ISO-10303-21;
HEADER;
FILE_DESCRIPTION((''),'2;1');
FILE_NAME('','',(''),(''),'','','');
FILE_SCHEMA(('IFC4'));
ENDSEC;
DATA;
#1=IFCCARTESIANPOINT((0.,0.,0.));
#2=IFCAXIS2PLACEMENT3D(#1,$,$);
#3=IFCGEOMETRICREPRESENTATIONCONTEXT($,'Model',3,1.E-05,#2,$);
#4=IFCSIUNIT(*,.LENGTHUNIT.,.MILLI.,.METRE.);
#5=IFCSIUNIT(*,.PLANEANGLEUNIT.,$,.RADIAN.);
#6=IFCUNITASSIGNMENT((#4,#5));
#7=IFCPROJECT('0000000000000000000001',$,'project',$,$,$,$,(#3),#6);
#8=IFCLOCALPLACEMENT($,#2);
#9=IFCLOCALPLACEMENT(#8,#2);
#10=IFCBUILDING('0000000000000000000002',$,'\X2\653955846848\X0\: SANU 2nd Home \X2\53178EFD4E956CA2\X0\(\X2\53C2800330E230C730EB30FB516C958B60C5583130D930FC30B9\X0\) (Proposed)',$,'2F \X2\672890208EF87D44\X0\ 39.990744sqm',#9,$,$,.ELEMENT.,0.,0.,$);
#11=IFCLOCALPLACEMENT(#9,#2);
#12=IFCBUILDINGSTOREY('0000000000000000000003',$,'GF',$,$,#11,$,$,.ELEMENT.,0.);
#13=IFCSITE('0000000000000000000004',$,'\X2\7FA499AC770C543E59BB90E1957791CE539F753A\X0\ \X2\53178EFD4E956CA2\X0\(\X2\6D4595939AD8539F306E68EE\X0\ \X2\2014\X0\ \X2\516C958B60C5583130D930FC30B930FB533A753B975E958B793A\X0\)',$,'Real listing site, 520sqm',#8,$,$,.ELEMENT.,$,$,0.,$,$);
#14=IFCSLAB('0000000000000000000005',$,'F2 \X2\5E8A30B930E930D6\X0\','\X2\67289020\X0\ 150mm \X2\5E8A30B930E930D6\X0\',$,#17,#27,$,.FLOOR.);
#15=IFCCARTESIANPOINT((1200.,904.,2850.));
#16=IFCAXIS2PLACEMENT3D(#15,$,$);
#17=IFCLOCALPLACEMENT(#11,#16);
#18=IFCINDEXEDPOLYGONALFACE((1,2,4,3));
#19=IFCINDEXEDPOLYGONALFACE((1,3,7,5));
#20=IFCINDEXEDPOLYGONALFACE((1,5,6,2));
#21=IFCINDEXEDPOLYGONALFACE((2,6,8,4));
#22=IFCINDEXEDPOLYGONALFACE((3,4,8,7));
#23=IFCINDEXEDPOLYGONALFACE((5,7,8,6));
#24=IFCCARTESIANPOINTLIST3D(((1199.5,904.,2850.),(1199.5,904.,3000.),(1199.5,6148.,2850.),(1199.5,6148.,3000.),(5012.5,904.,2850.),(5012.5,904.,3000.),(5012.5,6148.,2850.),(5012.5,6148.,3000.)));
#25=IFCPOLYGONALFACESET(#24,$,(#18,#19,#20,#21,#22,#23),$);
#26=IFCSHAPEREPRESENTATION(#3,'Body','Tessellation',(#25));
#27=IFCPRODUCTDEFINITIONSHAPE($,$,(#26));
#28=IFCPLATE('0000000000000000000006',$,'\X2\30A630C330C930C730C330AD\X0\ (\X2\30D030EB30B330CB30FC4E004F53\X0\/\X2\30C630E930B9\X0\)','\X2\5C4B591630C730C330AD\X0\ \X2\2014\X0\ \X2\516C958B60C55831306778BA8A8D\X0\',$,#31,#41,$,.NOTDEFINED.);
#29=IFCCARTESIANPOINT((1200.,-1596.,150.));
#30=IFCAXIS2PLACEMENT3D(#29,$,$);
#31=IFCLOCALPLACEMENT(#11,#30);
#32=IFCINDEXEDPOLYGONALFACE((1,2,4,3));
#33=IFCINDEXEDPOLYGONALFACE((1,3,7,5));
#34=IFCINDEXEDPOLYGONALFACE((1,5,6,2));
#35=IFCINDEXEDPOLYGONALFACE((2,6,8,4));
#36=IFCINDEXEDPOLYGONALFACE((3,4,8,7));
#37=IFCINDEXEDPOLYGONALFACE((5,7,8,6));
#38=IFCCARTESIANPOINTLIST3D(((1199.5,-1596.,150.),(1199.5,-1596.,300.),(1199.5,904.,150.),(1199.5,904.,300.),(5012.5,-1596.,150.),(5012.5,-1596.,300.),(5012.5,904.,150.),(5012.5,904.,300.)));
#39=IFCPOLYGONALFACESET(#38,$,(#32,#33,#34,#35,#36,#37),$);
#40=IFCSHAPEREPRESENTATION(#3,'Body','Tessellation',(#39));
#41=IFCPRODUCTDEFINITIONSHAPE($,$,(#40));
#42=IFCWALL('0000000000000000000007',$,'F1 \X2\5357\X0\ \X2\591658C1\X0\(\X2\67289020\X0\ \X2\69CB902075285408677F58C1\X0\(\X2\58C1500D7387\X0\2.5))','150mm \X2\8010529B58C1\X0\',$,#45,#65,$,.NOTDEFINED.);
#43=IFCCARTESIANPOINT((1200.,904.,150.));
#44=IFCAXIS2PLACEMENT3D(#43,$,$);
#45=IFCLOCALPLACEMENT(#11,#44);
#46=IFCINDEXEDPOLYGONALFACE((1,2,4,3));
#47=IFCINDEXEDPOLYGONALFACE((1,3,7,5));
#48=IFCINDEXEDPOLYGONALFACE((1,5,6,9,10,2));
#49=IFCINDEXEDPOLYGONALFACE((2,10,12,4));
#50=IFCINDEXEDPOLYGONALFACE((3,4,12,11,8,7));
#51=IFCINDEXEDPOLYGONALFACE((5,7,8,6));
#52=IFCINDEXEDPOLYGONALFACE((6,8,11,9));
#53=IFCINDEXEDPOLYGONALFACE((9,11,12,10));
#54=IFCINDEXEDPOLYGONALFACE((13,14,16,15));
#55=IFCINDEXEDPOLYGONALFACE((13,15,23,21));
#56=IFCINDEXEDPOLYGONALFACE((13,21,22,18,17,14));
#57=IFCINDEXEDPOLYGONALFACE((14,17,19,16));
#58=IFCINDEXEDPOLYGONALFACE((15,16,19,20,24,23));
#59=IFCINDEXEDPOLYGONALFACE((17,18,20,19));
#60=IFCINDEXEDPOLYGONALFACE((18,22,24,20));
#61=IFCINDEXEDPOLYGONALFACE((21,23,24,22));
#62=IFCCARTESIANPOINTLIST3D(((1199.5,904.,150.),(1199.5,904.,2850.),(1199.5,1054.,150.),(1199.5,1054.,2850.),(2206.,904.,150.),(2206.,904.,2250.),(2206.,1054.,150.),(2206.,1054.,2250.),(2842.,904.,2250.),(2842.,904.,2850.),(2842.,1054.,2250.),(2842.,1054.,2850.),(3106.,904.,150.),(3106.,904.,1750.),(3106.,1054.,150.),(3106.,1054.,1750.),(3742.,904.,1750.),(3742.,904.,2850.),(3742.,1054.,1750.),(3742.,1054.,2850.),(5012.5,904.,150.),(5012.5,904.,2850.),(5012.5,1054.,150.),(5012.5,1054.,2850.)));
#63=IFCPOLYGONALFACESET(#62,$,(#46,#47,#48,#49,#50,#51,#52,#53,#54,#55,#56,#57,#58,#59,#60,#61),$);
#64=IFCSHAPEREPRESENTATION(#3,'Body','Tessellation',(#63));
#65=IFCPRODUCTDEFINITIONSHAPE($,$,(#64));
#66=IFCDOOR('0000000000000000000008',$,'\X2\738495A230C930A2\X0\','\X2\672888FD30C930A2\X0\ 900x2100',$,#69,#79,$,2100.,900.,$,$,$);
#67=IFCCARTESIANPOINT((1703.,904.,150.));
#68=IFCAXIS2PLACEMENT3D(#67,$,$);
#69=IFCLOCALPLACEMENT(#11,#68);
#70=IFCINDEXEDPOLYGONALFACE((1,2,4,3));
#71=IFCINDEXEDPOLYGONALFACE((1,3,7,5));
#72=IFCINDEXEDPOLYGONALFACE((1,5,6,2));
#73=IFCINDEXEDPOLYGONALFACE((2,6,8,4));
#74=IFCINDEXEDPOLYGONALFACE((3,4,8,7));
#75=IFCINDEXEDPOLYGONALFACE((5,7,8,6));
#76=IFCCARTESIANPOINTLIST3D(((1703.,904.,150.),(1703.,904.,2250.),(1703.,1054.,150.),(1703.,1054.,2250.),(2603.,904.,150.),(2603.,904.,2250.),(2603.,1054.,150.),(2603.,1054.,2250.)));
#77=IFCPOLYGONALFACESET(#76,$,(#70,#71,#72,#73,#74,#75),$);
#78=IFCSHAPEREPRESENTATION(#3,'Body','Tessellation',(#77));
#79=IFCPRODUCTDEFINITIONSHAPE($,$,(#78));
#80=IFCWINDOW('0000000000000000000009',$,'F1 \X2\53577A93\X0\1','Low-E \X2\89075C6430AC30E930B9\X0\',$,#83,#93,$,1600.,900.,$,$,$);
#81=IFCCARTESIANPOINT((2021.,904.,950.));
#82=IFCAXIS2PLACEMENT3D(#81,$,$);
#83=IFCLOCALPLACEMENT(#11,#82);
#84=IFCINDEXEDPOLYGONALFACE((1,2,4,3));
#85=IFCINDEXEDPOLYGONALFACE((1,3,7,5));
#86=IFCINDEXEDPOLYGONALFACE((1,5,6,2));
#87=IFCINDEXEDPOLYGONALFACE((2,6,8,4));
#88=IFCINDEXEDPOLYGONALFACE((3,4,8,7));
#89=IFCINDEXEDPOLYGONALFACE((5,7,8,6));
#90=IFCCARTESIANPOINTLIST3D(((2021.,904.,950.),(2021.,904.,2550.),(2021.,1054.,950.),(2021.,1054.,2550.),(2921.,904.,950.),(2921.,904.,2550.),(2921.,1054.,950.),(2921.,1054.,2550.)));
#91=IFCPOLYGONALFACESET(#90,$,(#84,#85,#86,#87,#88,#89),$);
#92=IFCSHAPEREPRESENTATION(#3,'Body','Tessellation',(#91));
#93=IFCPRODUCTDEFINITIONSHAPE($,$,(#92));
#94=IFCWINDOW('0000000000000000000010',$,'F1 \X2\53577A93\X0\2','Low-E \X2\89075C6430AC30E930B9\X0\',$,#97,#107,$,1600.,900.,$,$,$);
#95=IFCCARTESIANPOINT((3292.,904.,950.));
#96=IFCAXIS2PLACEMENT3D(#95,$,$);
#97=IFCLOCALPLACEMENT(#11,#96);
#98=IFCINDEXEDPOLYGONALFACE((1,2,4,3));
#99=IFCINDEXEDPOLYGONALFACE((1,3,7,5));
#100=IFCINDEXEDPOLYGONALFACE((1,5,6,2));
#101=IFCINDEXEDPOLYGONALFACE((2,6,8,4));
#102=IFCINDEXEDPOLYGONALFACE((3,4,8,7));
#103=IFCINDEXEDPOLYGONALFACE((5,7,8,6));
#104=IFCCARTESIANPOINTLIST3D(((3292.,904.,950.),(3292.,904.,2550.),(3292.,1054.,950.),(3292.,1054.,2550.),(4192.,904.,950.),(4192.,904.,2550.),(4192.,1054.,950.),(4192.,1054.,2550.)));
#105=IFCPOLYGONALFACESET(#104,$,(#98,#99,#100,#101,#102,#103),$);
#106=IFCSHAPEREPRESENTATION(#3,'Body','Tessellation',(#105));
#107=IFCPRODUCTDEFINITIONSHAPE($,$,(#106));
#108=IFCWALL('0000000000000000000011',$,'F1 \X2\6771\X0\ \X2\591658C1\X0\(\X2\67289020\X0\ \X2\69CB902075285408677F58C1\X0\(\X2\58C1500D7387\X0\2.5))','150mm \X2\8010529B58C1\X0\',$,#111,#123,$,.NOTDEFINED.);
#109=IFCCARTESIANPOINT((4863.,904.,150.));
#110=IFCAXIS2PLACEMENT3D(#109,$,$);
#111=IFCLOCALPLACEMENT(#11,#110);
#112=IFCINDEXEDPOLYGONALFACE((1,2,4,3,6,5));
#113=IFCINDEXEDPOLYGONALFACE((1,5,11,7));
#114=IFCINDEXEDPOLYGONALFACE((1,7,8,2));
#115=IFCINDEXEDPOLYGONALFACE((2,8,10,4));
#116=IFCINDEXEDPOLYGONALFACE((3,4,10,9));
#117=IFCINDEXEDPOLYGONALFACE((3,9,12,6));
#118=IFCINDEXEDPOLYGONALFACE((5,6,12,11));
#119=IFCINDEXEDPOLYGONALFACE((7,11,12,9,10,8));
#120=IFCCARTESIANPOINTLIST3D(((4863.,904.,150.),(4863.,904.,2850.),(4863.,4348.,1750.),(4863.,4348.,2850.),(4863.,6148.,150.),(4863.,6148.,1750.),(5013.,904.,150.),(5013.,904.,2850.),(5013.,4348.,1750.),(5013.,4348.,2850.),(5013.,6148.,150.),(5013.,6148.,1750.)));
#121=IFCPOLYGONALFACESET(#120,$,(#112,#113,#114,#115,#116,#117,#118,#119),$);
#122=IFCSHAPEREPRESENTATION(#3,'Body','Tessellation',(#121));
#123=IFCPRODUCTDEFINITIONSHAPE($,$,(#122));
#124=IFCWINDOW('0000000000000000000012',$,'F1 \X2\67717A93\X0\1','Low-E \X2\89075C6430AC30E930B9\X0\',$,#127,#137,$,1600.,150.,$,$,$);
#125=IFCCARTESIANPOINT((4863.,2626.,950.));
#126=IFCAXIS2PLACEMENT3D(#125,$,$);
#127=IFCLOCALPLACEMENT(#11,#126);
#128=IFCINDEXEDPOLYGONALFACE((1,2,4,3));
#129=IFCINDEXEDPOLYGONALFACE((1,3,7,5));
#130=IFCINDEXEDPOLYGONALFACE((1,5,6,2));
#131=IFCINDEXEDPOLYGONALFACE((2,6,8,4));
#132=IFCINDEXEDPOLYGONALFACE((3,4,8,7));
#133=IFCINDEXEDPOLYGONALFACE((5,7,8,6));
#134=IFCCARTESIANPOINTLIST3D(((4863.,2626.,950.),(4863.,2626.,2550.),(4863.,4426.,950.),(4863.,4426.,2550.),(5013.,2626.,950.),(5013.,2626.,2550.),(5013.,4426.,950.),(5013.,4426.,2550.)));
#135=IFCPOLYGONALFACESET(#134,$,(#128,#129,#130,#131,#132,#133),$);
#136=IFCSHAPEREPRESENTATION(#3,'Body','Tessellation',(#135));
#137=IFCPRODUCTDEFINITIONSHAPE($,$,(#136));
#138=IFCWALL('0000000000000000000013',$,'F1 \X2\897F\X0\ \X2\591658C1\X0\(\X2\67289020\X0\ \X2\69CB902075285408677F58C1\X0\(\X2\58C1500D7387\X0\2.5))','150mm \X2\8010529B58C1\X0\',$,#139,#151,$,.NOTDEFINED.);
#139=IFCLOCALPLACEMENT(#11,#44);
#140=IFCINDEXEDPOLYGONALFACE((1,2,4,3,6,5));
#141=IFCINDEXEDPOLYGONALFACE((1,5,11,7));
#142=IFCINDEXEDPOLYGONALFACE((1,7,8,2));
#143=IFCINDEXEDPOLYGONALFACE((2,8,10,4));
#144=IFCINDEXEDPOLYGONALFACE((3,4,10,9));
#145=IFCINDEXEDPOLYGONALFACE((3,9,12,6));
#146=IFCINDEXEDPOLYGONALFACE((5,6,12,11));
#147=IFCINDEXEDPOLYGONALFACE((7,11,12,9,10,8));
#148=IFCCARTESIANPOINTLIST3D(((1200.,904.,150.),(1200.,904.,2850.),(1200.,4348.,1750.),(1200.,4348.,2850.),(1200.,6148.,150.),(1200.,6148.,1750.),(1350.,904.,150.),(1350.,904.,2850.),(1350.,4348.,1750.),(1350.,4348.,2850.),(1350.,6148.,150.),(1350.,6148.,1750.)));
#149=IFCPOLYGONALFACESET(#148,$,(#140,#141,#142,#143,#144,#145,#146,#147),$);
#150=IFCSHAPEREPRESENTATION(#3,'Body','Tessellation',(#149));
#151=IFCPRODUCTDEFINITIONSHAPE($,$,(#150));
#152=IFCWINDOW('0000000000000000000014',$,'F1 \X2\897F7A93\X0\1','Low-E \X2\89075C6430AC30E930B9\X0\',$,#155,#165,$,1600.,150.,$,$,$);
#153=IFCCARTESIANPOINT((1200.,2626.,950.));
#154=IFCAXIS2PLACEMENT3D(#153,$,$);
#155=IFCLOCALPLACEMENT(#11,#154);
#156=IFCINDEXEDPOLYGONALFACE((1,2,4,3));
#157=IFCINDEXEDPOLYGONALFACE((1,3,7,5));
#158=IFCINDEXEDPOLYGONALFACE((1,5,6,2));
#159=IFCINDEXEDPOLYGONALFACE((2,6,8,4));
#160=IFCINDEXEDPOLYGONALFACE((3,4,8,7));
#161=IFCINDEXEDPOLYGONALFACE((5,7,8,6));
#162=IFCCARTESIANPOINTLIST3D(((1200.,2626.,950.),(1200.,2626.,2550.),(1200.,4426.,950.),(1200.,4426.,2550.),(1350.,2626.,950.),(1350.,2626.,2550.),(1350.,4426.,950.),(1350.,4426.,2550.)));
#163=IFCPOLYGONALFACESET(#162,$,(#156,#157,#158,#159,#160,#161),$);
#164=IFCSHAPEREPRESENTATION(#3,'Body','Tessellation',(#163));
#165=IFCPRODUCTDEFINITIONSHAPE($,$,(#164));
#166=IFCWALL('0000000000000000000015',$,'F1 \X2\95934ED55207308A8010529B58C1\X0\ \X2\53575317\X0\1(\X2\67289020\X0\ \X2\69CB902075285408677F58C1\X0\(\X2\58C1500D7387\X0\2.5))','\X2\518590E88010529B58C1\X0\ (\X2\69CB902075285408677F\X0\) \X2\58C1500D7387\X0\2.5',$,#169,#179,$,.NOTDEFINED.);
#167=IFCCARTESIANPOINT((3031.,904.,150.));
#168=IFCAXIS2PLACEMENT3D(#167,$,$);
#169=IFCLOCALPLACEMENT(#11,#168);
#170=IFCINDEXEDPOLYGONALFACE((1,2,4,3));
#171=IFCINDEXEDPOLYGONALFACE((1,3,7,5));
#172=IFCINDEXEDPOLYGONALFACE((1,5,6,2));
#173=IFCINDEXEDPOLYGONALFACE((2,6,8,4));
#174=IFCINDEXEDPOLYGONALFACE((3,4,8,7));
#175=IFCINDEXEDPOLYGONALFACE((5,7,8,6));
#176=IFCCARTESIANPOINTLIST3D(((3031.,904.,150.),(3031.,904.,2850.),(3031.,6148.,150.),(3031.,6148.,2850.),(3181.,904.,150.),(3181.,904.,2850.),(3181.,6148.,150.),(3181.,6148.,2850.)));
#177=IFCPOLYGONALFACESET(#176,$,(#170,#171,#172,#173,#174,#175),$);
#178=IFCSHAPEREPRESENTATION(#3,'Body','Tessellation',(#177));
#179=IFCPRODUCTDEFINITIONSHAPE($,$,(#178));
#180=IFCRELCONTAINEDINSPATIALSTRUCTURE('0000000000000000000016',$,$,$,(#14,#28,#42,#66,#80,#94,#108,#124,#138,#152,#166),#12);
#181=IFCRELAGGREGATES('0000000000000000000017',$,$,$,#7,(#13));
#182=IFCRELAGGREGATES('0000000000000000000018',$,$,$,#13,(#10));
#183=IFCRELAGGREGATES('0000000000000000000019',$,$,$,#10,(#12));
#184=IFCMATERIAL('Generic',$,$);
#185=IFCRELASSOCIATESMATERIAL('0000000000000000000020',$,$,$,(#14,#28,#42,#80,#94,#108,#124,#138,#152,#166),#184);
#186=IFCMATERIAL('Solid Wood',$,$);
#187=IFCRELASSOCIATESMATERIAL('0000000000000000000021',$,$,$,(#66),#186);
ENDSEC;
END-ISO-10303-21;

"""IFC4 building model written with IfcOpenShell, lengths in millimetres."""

from ifc_helpers import new_model, si_unit, frame, frame_2d, origin, place, context, project, spatial, rectangle, extrude, material, element, fill, save


model = new_model("IFC4")

# Units and contexts
model_context = context("Model", 3, precision=1e-05, world=origin())
ifc_project = project(units=[si_unit("LENGTHUNIT", "METRE", prefix="MILLI"), si_unit("PLANEANGLEUNIT", "RADIAN")], contexts=[model_context])

# Site, building, storey
site_placement = place(None, origin())
site = spatial("IfcSite", under=ifc_project, at=site_placement, Name="群馬県吾妻郡長野原町 北軽井沢(浅間高原の森 — 公開情報ベース・区画非開示)", ObjectType="Real listing site, 520sqm", CompositionType="ELEMENT", RefElevation=0.0)
building_placement = place(site_placement, origin())
building = spatial("IfcBuilding", under=site, at=building_placement, Name="改善案: SANU 2nd Home 北軽井沢(参考モデル・公開情報ベース) (Proposed)", ObjectType="2F 木造軸組 39.990744sqm", CompositionType="ELEMENT", ElevationOfRefHeight=0.0, ElevationOfTerrain=0.0)
storey_placement = place(building_placement, origin())
storey = spatial("IfcBuildingStorey", under=building, at=storey_placement, Name="GF", CompositionType="ELEMENT", Elevation=0.0)

# Slab
ifc_material_1 = material(Name="Generic")
slab_1_placement = place(storey_placement, frame((1200.0, 904.0, 2850.0)))
element("IfcSlab", 1, at=slab_1_placement, inside=storey, material=ifc_material_1, Name="F2 床スラブ", Description="木造 150mm 床スラブ", PredefinedType="FLOOR", context=model_context, shape_type="SweptSolid", body=[
    extrude(rectangle(XDim=3813.0, YDim=5244.0, at=frame_2d((1906.0, 2622.0))), frame((1200.0, 904.0, 2850.0)), (0.0, 0.0, 1.0), 150.0),
])

# Plate
plate_placement = place(storey_placement, frame((1200.0, -1596.0, 150.0)))
element("IfcPlate", 2, at=plate_placement, inside=storey, material=ifc_material_1, Name="ウッドデッキ (バルコニー一体/テラス)", Description="屋外デッキ — 公開情報で確認", PredefinedType="NOTDEFINED", context=model_context, shape_type="SweptSolid", body=[
    extrude(rectangle(XDim=3813.0, YDim=2500.0, at=frame_2d((1906.0, 1250.0))), frame((1200.0, -1596.0, 150.0)), (0.0, 0.0, 1.0), 150.0),
])

# Wall, openings, door, windows
wall_1_placement = place(storey_placement, frame((1200.0, 904.0, 150.0)))
wall_1 = element("IfcWall", 3, at=wall_1_placement, inside=storey, material=ifc_material_1, Name="F1 南 外壁(木造 構造用合板壁(壁倍率2.5))", Description="150mm 耐力壁", PredefinedType="NOTDEFINED", context=model_context, shape_type="SweptSolid", body=[
    extrude(rectangle(XDim=3813.0, YDim=150.0, at=frame_2d((1906.0, 75.0))), frame((1200.0, 904.0, 150.0)), (0.0, 0.0, 1.0), 2700.0),
])
opening_1_placement = place(storey_placement, frame((1703.0, 904.0, 150.0)))
opening_1 = element("IfcOpeningElement", 4, at=opening_1_placement, cuts=wall_1, PredefinedType="NOTDEFINED", context=model_context, shape_type="SweptSolid", body=[
    extrude(rectangle(XDim=900.0, YDim=150.0, at=frame_2d((450.0, 75.0))), frame((1703.0, 904.0, 150.0)), (0.0, 0.0, 1.0), 2100.0),
])
opening_2_placement = place(storey_placement, frame((2021.0, 904.0, 950.0)))
opening_2 = element("IfcOpeningElement", 5, at=opening_2_placement, cuts=wall_1, PredefinedType="NOTDEFINED", context=model_context, shape_type="SweptSolid", body=[
    extrude(rectangle(XDim=900.0, YDim=150.0, at=frame_2d((450.0, 75.0))), frame((2021.0, 904.0, 950.0)), (0.0, 0.0, 1.0), 1600.0),
])
opening_3_placement = place(storey_placement, frame((3292.0, 904.0, 950.0)))
opening_3 = element("IfcOpeningElement", 6, at=opening_3_placement, cuts=wall_1, PredefinedType="NOTDEFINED", context=model_context, shape_type="SweptSolid", body=[
    extrude(rectangle(XDim=900.0, YDim=150.0, at=frame_2d((450.0, 75.0))), frame((3292.0, 904.0, 950.0)), (0.0, 0.0, 1.0), 1600.0),
])
ifc_material_2 = material(Name="Solid Wood")
door_placement = place(storey_placement, frame((1703.0, 904.0, 150.0)))
door = element("IfcDoor", 7, at=door_placement, inside=storey, material=ifc_material_2, Name="玄関ドア", Description="木製ドア 900x2100", OverallHeight=2100.0, OverallWidth=900.0, context=model_context, shape_type="SweptSolid", body=[
    extrude(rectangle(XDim=900.0, YDim=150.0, at=frame_2d((450.0, 75.0))), frame((1703.0, 904.0, 150.0)), (0.0, 0.0, 1.0), 2100.0),
])
fill(opening_1, door)
window_1_placement = place(storey_placement, frame((2021.0, 904.0, 950.0)))
window_1 = element("IfcWindow", 8, at=window_1_placement, inside=storey, material=ifc_material_1, Name="F1 南窓1", Description="Low-E 複層ガラス", OverallHeight=1600.0, OverallWidth=900.0, context=model_context, shape_type="SweptSolid", body=[
    extrude(rectangle(XDim=900.0, YDim=150.0, at=frame_2d((450.0, 75.0))), frame((2021.0, 904.0, 950.0)), (0.0, 0.0, 1.0), 1600.0),
])
fill(opening_2, window_1)
window_2_placement = place(storey_placement, frame((3292.0, 904.0, 950.0)))
window_2 = element("IfcWindow", 9, at=window_2_placement, inside=storey, material=ifc_material_1, Name="F1 南窓2", Description="Low-E 複層ガラス", OverallHeight=1600.0, OverallWidth=900.0, context=model_context, shape_type="SweptSolid", body=[
    extrude(rectangle(XDim=900.0, YDim=150.0, at=frame_2d((450.0, 75.0))), frame((3292.0, 904.0, 950.0)), (0.0, 0.0, 1.0), 1600.0),
])
fill(opening_3, window_2)

# Walls, openings, windows
wall_2_placement = place(storey_placement, frame((4863.0, 904.0, 150.0)))
wall_2 = element("IfcWall", 10, at=wall_2_placement, inside=storey, material=ifc_material_1, Name="F1 東 外壁(木造 構造用合板壁(壁倍率2.5))", Description="150mm 耐力壁", PredefinedType="NOTDEFINED", context=model_context, shape_type="SweptSolid", body=[
    extrude(rectangle(XDim=150.0, YDim=5244.0, at=frame_2d((75.0, 2622.0))), frame((4863.0, 904.0, 150.0)), (0.0, 0.0, 1.0), 2700.0),
])
opening_4_placement = place(storey_placement, frame((4863.0, 2626.0, 950.0)))
opening_4 = element("IfcOpeningElement", 11, at=opening_4_placement, cuts=wall_2, PredefinedType="NOTDEFINED", context=model_context, shape_type="SweptSolid", body=[
    extrude(rectangle(XDim=150.0, YDim=1800.0, at=frame_2d((75.0, 900.0))), frame((4863.0, 2626.0, 950.0)), (0.0, 0.0, 1.0), 1600.0),
])
window_3_placement = place(storey_placement, frame((4863.0, 2626.0, 950.0)))
window_3 = element("IfcWindow", 12, at=window_3_placement, inside=storey, material=ifc_material_1, Name="F1 東窓1", Description="Low-E 複層ガラス", OverallHeight=1600.0, OverallWidth=150.0, context=model_context, shape_type="SweptSolid", body=[
    extrude(rectangle(XDim=150.0, YDim=1800.0, at=frame_2d((75.0, 900.0))), frame((4863.0, 2626.0, 950.0)), (0.0, 0.0, 1.0), 1600.0),
])
fill(opening_4, window_3)
wall_3_placement = place(storey_placement, frame((1200.0, 904.0, 150.0)))
wall_3 = element("IfcWall", 13, at=wall_3_placement, inside=storey, material=ifc_material_1, Name="F1 西 外壁(木造 構造用合板壁(壁倍率2.5))", Description="150mm 耐力壁", PredefinedType="NOTDEFINED", context=model_context, shape_type="SweptSolid", body=[
    extrude(rectangle(XDim=150.0, YDim=5244.0, at=frame_2d((75.0, 2622.0))), frame((1200.0, 904.0, 150.0)), (0.0, 0.0, 1.0), 2700.0),
])
opening_5_placement = place(storey_placement, frame((1200.0, 2626.0, 950.0)))
opening_5 = element("IfcOpeningElement", 14, at=opening_5_placement, cuts=wall_3, PredefinedType="NOTDEFINED", context=model_context, shape_type="SweptSolid", body=[
    extrude(rectangle(XDim=150.0, YDim=1800.0, at=frame_2d((75.0, 900.0))), frame((1200.0, 2626.0, 950.0)), (0.0, 0.0, 1.0), 1600.0),
])
window_4_placement = place(storey_placement, frame((1200.0, 2626.0, 950.0)))
window_4 = element("IfcWindow", 15, at=window_4_placement, inside=storey, material=ifc_material_1, Name="F1 西窓1", Description="Low-E 複層ガラス", OverallHeight=1600.0, OverallWidth=150.0, context=model_context, shape_type="SweptSolid", body=[
    extrude(rectangle(XDim=150.0, YDim=1800.0, at=frame_2d((75.0, 900.0))), frame((1200.0, 2626.0, 950.0)), (0.0, 0.0, 1.0), 1600.0),
])
fill(opening_5, window_4)

# Wall
wall_4_placement = place(storey_placement, frame((3031.0, 904.0, 150.0)))
element("IfcWall", 16, at=wall_4_placement, inside=storey, material=ifc_material_1, Name="F1 間仕切り耐力壁 南北1(木造 構造用合板壁(壁倍率2.5))", Description="内部耐力壁 (構造用合板) 壁倍率2.5", PredefinedType="NOTDEFINED", context=model_context, shape_type="SweptSolid", body=[
    extrude(rectangle(XDim=150.0, YDim=5244.0, at=frame_2d((75.0, 2622.0))), frame((3031.0, 904.0, 150.0)), (0.0, 0.0, 1.0), 2700.0),
])

save(model, "model.ifc")
